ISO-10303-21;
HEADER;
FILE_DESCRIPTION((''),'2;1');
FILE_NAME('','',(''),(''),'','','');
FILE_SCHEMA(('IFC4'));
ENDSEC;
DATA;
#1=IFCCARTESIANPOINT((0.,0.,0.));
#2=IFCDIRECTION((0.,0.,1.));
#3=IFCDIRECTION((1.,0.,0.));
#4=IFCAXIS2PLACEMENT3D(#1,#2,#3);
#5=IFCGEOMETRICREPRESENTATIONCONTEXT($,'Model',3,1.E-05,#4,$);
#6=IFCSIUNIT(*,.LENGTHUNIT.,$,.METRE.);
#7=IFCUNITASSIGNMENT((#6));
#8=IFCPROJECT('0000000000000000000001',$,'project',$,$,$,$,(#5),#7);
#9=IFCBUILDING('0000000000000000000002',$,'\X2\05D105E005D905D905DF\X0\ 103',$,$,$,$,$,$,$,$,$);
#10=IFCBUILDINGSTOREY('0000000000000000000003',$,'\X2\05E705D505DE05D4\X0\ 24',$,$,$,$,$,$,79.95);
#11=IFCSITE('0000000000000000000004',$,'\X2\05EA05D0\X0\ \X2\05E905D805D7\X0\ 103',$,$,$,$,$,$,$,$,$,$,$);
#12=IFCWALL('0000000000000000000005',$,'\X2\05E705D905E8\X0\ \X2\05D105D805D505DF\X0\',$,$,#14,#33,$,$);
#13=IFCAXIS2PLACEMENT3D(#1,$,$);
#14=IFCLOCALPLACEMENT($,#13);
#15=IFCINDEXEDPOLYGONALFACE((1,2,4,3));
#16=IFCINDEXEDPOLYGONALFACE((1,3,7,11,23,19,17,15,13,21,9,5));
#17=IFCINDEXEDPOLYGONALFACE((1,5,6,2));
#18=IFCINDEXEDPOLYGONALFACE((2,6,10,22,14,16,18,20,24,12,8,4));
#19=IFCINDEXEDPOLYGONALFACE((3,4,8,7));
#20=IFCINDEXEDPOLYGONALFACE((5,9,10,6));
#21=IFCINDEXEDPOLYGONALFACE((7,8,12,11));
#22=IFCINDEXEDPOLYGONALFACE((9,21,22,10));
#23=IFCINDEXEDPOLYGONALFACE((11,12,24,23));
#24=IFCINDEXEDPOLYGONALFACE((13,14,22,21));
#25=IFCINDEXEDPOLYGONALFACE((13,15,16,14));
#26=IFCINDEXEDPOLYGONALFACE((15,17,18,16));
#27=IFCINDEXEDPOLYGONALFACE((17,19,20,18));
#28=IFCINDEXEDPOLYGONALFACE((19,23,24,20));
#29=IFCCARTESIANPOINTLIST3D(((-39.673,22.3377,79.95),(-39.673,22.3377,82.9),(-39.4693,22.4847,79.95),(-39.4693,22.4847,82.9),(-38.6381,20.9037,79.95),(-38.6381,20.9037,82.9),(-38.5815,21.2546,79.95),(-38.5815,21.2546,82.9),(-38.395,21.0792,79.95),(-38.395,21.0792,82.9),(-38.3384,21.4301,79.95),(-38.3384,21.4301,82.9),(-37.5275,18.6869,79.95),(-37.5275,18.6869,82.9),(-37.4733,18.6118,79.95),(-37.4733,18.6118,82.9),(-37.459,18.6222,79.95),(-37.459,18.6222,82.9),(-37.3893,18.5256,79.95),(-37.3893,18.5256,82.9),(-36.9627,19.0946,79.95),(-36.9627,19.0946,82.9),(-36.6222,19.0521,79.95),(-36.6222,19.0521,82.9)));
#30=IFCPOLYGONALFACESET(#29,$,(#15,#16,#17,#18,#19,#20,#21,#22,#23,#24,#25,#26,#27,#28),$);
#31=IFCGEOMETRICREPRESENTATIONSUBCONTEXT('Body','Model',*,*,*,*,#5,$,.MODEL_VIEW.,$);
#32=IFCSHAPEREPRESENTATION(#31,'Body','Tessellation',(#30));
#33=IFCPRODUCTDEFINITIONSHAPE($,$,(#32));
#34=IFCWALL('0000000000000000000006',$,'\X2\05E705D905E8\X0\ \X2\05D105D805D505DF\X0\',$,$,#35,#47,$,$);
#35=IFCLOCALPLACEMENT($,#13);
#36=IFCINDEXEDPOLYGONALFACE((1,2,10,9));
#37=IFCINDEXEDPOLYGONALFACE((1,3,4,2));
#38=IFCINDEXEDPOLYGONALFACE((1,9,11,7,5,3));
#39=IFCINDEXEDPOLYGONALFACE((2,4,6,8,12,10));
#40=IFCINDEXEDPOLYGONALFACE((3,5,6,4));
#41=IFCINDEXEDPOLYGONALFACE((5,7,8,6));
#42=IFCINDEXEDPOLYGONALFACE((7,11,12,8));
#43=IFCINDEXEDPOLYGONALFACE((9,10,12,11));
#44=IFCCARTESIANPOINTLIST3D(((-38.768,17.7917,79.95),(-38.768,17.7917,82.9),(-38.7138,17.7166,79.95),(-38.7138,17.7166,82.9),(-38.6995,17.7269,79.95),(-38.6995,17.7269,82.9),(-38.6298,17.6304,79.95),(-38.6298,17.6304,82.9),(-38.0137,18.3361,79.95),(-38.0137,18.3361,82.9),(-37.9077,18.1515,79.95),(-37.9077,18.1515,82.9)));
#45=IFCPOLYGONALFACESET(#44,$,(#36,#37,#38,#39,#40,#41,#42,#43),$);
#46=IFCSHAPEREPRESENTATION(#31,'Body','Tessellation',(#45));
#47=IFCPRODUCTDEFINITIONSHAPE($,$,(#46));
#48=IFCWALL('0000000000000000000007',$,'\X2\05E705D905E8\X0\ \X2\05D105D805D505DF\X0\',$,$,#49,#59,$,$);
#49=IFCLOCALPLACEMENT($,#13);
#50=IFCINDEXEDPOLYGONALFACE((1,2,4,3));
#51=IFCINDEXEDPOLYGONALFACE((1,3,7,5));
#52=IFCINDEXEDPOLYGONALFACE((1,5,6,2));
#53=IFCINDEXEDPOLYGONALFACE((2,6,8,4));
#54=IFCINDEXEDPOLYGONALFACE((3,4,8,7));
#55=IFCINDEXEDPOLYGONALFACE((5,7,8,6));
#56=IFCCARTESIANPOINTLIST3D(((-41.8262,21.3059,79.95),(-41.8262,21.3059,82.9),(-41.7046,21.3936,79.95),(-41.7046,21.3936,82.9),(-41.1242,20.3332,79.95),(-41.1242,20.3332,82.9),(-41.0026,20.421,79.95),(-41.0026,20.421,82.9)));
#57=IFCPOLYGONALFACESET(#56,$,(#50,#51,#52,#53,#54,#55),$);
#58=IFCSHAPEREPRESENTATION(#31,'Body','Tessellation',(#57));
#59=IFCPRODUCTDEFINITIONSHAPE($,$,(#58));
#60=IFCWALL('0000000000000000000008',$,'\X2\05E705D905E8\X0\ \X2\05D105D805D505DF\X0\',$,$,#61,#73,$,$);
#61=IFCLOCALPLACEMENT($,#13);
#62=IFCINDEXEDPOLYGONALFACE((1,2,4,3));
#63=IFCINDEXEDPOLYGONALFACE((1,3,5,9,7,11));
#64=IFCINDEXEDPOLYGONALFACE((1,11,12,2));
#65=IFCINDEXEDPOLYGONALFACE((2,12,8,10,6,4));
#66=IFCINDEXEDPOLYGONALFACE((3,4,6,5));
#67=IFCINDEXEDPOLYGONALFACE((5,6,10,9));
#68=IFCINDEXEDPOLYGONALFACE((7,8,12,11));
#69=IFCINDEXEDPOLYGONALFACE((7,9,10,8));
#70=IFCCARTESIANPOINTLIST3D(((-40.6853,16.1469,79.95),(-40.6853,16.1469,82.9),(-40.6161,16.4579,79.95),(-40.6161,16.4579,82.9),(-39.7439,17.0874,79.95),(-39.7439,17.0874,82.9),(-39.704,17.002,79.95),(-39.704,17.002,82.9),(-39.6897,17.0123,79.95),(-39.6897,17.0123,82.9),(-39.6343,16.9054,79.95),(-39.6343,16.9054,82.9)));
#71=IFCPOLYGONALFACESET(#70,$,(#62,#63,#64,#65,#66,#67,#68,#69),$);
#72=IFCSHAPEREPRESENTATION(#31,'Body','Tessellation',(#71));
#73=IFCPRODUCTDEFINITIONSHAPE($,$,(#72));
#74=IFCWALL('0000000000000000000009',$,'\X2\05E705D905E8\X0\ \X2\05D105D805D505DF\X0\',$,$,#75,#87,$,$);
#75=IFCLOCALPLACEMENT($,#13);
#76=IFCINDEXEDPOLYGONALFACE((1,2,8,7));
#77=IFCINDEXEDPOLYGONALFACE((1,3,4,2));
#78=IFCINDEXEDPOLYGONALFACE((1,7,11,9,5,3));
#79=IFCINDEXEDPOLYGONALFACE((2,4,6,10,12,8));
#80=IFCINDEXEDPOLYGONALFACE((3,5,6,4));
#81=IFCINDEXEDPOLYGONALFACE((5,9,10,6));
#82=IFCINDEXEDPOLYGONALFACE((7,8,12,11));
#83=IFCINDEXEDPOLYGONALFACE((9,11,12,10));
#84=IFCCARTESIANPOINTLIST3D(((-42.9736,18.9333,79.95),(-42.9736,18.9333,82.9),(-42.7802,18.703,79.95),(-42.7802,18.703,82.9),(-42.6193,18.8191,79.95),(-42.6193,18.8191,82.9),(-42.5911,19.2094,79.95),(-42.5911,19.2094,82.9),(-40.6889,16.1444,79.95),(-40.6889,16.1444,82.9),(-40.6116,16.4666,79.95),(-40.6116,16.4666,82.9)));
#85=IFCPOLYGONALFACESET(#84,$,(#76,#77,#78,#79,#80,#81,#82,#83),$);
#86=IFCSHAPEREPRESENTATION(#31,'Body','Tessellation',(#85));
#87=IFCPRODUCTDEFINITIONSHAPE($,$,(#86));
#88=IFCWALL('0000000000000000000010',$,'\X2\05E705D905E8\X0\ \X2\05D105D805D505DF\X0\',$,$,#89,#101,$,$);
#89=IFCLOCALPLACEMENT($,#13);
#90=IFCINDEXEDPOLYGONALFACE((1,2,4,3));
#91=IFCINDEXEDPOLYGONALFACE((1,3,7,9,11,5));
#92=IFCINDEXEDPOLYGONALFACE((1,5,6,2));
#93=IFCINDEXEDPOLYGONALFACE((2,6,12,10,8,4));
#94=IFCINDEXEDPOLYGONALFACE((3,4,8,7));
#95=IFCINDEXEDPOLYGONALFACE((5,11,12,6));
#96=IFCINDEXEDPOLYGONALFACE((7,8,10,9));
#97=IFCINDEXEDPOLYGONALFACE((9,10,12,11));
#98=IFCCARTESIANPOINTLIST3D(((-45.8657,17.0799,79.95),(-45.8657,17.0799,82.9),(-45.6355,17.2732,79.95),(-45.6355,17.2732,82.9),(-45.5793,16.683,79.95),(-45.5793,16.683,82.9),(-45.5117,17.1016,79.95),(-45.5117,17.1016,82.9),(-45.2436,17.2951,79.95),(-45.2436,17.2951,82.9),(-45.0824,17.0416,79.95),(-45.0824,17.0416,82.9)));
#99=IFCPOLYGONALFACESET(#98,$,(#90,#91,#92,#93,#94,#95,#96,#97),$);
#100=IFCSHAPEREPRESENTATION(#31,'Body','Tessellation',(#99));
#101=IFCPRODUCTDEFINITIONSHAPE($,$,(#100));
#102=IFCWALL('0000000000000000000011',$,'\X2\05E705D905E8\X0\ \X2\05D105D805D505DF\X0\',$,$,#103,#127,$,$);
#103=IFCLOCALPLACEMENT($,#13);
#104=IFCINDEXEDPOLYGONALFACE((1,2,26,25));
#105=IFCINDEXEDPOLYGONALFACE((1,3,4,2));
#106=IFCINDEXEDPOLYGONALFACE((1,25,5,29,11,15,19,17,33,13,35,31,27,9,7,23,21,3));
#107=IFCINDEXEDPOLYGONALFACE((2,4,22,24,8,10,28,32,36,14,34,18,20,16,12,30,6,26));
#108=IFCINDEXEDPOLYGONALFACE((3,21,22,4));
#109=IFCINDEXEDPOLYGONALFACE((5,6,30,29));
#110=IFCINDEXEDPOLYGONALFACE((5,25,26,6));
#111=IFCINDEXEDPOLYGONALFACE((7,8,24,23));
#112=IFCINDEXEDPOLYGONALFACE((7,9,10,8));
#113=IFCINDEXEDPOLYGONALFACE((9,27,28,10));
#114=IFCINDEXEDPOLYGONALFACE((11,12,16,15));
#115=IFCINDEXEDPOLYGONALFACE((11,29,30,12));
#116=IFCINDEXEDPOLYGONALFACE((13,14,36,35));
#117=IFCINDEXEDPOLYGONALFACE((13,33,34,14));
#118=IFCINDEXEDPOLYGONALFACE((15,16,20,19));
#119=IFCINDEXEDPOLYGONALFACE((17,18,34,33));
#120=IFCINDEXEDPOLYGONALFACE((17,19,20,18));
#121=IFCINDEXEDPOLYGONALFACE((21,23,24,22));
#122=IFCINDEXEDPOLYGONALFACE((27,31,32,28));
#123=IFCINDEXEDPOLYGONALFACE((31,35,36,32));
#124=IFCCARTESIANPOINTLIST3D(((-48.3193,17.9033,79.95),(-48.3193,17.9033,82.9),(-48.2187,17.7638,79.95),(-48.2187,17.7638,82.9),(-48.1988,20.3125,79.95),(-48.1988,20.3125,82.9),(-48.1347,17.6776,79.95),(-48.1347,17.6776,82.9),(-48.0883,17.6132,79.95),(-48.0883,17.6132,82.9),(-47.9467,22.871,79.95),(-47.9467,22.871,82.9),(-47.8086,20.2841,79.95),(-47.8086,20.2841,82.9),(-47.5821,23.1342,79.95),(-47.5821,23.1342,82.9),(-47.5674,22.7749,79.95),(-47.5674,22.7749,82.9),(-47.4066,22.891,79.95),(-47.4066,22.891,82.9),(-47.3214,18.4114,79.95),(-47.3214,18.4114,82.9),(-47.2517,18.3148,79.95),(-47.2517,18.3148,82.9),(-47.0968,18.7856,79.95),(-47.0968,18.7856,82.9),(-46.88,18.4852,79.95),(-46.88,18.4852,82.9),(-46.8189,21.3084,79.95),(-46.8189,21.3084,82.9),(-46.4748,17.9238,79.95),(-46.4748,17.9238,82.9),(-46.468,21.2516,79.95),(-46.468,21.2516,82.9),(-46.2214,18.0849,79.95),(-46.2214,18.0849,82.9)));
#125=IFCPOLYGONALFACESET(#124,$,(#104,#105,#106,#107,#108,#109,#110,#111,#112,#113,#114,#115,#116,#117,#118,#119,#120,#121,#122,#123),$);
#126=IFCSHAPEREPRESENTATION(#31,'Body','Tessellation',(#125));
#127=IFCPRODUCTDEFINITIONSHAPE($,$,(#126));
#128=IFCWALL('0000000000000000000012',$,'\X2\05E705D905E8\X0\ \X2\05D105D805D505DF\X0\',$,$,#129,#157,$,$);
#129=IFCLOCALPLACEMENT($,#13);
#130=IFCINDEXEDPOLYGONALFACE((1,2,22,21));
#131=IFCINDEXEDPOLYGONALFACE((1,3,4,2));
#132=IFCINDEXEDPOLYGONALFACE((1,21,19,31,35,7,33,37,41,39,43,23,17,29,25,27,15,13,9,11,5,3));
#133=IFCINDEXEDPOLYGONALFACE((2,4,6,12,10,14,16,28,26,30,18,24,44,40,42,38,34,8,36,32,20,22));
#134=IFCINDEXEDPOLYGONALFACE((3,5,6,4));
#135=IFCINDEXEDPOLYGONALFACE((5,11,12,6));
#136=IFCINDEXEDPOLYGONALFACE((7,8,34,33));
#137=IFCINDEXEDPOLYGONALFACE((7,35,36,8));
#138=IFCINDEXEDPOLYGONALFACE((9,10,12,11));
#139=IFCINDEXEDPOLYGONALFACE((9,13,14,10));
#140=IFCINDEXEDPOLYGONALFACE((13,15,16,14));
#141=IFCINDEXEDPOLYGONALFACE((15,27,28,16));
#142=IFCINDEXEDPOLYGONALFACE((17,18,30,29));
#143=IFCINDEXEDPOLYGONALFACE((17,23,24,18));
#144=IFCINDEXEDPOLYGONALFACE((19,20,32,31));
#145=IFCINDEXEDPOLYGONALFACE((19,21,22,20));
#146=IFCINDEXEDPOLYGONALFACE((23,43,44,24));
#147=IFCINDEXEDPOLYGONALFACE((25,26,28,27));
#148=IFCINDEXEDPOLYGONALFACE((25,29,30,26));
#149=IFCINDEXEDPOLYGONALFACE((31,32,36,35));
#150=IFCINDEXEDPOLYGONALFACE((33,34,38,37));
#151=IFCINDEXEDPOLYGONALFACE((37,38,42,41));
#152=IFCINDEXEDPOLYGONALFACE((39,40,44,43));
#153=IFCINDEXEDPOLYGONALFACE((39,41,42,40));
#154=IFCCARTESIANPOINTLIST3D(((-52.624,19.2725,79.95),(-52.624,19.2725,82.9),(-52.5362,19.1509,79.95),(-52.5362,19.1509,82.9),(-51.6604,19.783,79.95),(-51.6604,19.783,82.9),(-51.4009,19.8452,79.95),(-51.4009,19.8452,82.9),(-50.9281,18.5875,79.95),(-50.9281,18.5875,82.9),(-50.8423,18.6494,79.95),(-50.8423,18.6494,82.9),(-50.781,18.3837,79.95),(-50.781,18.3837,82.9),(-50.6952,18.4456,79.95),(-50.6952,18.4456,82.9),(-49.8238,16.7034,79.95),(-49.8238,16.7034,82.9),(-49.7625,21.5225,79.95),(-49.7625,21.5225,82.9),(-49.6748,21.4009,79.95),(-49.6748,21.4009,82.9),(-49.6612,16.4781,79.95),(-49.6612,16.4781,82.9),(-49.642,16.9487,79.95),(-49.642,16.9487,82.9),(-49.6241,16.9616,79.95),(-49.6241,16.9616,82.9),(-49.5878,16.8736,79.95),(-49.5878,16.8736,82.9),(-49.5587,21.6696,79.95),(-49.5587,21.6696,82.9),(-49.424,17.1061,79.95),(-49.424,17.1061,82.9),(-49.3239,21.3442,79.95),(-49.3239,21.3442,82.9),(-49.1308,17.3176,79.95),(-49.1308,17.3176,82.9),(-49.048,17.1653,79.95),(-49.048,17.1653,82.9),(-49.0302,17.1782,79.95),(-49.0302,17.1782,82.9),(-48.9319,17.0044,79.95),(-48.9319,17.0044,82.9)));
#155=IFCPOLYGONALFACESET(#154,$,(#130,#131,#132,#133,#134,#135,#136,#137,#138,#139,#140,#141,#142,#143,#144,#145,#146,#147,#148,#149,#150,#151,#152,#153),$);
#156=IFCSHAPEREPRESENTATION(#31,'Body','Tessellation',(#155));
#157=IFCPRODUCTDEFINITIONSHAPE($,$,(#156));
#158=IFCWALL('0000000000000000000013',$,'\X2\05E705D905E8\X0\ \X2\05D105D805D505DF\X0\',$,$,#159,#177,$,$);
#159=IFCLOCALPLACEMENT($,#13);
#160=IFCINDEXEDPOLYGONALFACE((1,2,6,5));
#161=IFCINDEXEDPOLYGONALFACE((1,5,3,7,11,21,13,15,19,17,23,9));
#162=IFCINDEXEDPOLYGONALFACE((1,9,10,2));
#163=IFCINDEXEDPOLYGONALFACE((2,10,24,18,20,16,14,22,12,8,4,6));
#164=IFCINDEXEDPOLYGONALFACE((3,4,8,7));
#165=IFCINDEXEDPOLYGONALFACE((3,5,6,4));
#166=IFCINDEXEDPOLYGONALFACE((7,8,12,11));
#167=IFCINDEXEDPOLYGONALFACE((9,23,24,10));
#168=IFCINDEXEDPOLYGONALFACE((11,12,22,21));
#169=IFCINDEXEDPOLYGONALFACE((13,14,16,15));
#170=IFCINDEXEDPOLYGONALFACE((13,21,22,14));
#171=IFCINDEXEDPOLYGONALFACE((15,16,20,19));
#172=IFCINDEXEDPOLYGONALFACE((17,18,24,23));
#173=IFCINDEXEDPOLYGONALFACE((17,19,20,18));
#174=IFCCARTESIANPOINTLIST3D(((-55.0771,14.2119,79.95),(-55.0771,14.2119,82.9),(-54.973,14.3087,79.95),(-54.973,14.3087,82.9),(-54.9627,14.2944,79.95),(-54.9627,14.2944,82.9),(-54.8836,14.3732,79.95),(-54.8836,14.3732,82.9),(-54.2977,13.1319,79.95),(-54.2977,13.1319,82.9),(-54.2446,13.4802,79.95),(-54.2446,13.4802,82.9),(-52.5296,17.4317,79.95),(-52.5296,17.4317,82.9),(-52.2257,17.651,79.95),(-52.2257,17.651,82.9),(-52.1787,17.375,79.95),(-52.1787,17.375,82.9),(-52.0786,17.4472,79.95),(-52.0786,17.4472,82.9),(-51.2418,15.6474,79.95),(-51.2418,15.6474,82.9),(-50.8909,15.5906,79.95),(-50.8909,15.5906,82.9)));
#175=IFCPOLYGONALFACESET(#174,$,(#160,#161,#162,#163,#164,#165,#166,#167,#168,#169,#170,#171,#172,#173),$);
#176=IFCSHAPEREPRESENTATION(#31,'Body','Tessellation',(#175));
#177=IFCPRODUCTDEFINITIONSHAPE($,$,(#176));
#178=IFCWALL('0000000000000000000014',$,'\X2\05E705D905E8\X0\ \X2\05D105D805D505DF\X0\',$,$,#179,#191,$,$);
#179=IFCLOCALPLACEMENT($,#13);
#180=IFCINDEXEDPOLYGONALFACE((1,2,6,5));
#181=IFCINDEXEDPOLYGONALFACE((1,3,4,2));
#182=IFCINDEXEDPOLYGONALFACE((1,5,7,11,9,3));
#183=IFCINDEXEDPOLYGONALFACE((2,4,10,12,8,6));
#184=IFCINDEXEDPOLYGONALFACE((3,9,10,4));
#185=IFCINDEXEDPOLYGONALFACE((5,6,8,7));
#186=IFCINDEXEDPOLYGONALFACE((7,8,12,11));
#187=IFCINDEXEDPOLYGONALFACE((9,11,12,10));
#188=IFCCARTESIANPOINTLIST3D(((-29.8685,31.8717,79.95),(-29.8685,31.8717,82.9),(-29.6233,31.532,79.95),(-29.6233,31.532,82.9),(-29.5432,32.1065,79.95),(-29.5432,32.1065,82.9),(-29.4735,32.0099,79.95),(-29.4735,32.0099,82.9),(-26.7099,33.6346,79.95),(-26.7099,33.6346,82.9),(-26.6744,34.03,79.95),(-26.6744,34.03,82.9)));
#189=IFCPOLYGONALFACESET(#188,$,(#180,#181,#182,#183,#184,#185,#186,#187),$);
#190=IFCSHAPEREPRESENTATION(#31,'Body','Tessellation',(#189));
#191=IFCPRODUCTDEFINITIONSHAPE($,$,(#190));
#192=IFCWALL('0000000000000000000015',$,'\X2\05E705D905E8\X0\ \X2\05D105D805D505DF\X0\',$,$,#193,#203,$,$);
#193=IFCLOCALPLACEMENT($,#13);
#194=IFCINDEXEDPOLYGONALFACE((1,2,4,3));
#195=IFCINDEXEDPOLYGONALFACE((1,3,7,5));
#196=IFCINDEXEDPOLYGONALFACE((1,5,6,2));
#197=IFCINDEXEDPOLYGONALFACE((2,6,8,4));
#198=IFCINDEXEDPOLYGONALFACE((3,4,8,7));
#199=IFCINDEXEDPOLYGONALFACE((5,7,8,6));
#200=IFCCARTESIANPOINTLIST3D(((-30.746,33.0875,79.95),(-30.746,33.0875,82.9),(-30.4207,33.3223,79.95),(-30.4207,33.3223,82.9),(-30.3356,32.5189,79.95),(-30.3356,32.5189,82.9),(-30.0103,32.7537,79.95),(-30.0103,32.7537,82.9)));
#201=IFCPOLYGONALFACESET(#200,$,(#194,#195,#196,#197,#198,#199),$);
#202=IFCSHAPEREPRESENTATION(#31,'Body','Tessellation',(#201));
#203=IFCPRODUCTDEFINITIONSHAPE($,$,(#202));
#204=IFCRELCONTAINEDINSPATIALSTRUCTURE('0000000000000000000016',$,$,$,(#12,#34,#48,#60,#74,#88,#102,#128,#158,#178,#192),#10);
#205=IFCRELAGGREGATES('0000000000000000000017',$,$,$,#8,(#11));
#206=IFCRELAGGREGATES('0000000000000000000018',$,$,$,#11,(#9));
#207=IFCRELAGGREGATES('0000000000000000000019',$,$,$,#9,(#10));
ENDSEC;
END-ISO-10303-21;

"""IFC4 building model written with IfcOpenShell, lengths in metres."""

from ifc_helpers import new_model, si_unit, frame, origin_with_axes, context, subcontext, project, spatial, polyline, outline, extrude, element, save


model = new_model("IFC4")

# Units and contexts
model_context = context("Model", 3, precision=1e-05, world=origin_with_axes())
body_context = subcontext(model_context, "Body", "Model", "MODEL_VIEW")
ifc_project = project(units=[si_unit("LENGTHUNIT", "METRE")], contexts=[model_context])

# Site, building, storey
site = spatial("IfcSite", under=ifc_project, Name="תא שטח 103")
building = spatial("IfcBuilding", under=site, Name="בניין 103")
storey = spatial("IfcBuildingStorey", under=building, Name="קומה 24", Elevation=79.95)

# Walls
element("IfcWall", 1, inside=storey, Name="קיר בטון", context=body_context, shape_type="SweptSolid", body=[
    extrude(outline(polyline([(-37.459, 18.6222), (-37.4733, 18.6118), (-37.5275, 18.6869), (-36.9627, 19.0946), (-38.395, 21.0792), (-38.6381, 20.9037), (-39.673, 22.3377), (-39.4693, 22.4847), (-38.5815, 21.2546), (-38.3384, 21.4301), (-36.6222, 19.0521), (-37.3893, 18.5256), (-37.459, 18.6222)])), frame((0.0, 0.0, 79.95)), (0.0, 0.0, 1.0), 2.95),
])
element("IfcWall", 2, inside=storey, Name="קיר בטון", context=body_context, shape_type="SweptSolid", body=[
    extrude(outline(polyline([(-38.6995, 17.7269), (-38.7138, 17.7166), (-38.768, 17.7917), (-38.0137, 18.3361), (-37.9077, 18.1515), (-38.6298, 17.6304), (-38.6995, 17.7269)])), frame((0.0, 0.0, 79.95)), (0.0, 0.0, 1.0), 2.95),
])
element("IfcWall", 3, inside=storey, Name="קיר בטון", context=body_context, shape_type="SweptSolid", body=[
    extrude(outline(polyline([(-41.0026, 20.421), (-41.1242, 20.3332), (-41.8262, 21.3059), (-41.7046, 21.3936), (-41.0026, 20.421)])), frame((0.0, 0.0, 79.95)), (0.0, 0.0, 1.0), 2.95),
])
element("IfcWall", 4, inside=storey, Name="קיר בטון", context=body_context, shape_type="SweptSolid", body=[
    extrude(outline(polyline([(-40.6161, 16.4579), (-39.7439, 17.0874), (-39.6897, 17.0123), (-39.704, 17.002), (-39.6343, 16.9054), (-40.6853, 16.1469), (-40.6161, 16.4579)])), frame((0.0, 0.0, 79.95)), (0.0, 0.0, 1.0), 2.95),
])
element("IfcWall", 5, inside=storey, Name="קיר בטון", context=body_context, shape_type="SweptSolid", body=[
    extrude(outline(polyline([(-42.5911, 19.2094), (-40.6116, 16.4666), (-40.6889, 16.1444), (-42.6193, 18.8191), (-42.7802, 18.703), (-42.9736, 18.9333), (-42.5911, 19.2094)])), frame((0.0, 0.0, 79.95)), (0.0, 0.0, 1.0), 2.95),
])
element("IfcWall", 6, inside=storey, Name="קיר בטון", context=body_context, shape_type="SweptSolid", body=[
    extrude(outline(polyline([(-45.5793, 16.683), (-45.8657, 17.0799), (-45.6355, 17.2732), (-45.5117, 17.1016), (-45.2436, 17.2951), (-45.0824, 17.0416), (-45.5793, 16.683)])), frame((0.0, 0.0, 79.95)), (0.0, 0.0, 1.0), 2.95),
])
element("IfcWall", 7, inside=storey, Name="קיר בטון", context=body_context, shape_type="SweptSolid", body=[
    extrude(outline(polyline([(-48.3193, 17.9033), (-47.0968, 18.7856), (-48.1988, 20.3125), (-46.8189, 21.3084), (-47.9467, 22.871), (-47.5821, 23.1342), (-47.4066, 22.891), (-47.5674, 22.7749), (-46.468, 21.2516), (-47.8086, 20.2841), (-46.2214, 18.0849), (-46.4748, 17.9238), (-46.88, 18.4852), (-48.0883, 17.6132), (-48.1347, 17.6776), (-47.2517, 18.3148), (-47.3214, 18.4114), (-48.2187, 17.7638), (-48.3193, 17.9033)])), frame((0.0, 0.0, 79.95)), (0.0, 0.0, 1.0), 2.95),
])
element("IfcWall", 8, inside=storey, Name="קיר בטון", context=body_context, shape_type="SweptSolid", body=[
    extrude(outline(polyline([(-49.048, 17.1653), (-48.9319, 17.0044), (-49.6612, 16.4781), (-49.8238, 16.7034), (-49.5878, 16.8736), (-49.642, 16.9487), (-49.6241, 16.9616), (-50.6952, 18.4456), (-50.781, 18.3837), (-50.9281, 18.5875), (-50.8423, 18.6494), (-51.6604, 19.783), (-52.5362, 19.1509), (-52.624, 19.2725), (-49.6748, 21.4009), (-49.7625, 21.5225), (-49.5587, 21.6696), (-49.3239, 21.3442), (-51.4009, 19.8452), (-49.424, 17.1061), (-49.1308, 17.3176), (-49.0302, 17.1782), (-49.048, 17.1653)])), frame((0.0, 0.0, 79.95)), (0.0, 0.0, 1.0), 2.95),
])
element("IfcWall", 9, inside=storey, Name="קיר בטון", context=body_context, shape_type="SweptSolid", body=[
    extrude(outline(polyline([(-54.2977, 13.1319), (-55.0771, 14.2119), (-54.9627, 14.2944), (-54.973, 14.3087), (-54.8836, 14.3732), (-54.2446, 13.4802), (-51.2418, 15.6474), (-52.5296, 17.4317), (-52.2257, 17.651), (-52.0786, 17.4472), (-52.1787, 17.375), (-50.8909, 15.5906), (-54.2977, 13.1319)])), frame((0.0, 0.0, 79.95)), (0.0, 0.0, 1.0), 2.95),
])
element("IfcWall", 10, inside=storey, Name="קיר בטון", context=body_context, shape_type="SweptSolid", body=[
    extrude(outline(polyline([(-26.6744, 34.03), (-26.7099, 33.6346), (-29.6233, 31.532), (-29.8685, 31.8717), (-29.5432, 32.1065), (-29.4735, 32.0099), (-26.6744, 34.03)])), frame((0.0, 0.0, 79.95)), (0.0, 0.0, 1.0), 2.95),
])
element("IfcWall", 11, inside=storey, Name="קיר בטון", context=body_context, shape_type="SweptSolid", body=[
    extrude(outline(polyline([(-30.0103, 32.7537), (-30.3356, 32.5189), (-30.746, 33.0875), (-30.4207, 33.3223), (-30.0103, 32.7537)])), frame((0.0, 0.0, 79.95)), (0.0, 0.0, 1.0), 2.95),
])

save(model, "model.ifc")
